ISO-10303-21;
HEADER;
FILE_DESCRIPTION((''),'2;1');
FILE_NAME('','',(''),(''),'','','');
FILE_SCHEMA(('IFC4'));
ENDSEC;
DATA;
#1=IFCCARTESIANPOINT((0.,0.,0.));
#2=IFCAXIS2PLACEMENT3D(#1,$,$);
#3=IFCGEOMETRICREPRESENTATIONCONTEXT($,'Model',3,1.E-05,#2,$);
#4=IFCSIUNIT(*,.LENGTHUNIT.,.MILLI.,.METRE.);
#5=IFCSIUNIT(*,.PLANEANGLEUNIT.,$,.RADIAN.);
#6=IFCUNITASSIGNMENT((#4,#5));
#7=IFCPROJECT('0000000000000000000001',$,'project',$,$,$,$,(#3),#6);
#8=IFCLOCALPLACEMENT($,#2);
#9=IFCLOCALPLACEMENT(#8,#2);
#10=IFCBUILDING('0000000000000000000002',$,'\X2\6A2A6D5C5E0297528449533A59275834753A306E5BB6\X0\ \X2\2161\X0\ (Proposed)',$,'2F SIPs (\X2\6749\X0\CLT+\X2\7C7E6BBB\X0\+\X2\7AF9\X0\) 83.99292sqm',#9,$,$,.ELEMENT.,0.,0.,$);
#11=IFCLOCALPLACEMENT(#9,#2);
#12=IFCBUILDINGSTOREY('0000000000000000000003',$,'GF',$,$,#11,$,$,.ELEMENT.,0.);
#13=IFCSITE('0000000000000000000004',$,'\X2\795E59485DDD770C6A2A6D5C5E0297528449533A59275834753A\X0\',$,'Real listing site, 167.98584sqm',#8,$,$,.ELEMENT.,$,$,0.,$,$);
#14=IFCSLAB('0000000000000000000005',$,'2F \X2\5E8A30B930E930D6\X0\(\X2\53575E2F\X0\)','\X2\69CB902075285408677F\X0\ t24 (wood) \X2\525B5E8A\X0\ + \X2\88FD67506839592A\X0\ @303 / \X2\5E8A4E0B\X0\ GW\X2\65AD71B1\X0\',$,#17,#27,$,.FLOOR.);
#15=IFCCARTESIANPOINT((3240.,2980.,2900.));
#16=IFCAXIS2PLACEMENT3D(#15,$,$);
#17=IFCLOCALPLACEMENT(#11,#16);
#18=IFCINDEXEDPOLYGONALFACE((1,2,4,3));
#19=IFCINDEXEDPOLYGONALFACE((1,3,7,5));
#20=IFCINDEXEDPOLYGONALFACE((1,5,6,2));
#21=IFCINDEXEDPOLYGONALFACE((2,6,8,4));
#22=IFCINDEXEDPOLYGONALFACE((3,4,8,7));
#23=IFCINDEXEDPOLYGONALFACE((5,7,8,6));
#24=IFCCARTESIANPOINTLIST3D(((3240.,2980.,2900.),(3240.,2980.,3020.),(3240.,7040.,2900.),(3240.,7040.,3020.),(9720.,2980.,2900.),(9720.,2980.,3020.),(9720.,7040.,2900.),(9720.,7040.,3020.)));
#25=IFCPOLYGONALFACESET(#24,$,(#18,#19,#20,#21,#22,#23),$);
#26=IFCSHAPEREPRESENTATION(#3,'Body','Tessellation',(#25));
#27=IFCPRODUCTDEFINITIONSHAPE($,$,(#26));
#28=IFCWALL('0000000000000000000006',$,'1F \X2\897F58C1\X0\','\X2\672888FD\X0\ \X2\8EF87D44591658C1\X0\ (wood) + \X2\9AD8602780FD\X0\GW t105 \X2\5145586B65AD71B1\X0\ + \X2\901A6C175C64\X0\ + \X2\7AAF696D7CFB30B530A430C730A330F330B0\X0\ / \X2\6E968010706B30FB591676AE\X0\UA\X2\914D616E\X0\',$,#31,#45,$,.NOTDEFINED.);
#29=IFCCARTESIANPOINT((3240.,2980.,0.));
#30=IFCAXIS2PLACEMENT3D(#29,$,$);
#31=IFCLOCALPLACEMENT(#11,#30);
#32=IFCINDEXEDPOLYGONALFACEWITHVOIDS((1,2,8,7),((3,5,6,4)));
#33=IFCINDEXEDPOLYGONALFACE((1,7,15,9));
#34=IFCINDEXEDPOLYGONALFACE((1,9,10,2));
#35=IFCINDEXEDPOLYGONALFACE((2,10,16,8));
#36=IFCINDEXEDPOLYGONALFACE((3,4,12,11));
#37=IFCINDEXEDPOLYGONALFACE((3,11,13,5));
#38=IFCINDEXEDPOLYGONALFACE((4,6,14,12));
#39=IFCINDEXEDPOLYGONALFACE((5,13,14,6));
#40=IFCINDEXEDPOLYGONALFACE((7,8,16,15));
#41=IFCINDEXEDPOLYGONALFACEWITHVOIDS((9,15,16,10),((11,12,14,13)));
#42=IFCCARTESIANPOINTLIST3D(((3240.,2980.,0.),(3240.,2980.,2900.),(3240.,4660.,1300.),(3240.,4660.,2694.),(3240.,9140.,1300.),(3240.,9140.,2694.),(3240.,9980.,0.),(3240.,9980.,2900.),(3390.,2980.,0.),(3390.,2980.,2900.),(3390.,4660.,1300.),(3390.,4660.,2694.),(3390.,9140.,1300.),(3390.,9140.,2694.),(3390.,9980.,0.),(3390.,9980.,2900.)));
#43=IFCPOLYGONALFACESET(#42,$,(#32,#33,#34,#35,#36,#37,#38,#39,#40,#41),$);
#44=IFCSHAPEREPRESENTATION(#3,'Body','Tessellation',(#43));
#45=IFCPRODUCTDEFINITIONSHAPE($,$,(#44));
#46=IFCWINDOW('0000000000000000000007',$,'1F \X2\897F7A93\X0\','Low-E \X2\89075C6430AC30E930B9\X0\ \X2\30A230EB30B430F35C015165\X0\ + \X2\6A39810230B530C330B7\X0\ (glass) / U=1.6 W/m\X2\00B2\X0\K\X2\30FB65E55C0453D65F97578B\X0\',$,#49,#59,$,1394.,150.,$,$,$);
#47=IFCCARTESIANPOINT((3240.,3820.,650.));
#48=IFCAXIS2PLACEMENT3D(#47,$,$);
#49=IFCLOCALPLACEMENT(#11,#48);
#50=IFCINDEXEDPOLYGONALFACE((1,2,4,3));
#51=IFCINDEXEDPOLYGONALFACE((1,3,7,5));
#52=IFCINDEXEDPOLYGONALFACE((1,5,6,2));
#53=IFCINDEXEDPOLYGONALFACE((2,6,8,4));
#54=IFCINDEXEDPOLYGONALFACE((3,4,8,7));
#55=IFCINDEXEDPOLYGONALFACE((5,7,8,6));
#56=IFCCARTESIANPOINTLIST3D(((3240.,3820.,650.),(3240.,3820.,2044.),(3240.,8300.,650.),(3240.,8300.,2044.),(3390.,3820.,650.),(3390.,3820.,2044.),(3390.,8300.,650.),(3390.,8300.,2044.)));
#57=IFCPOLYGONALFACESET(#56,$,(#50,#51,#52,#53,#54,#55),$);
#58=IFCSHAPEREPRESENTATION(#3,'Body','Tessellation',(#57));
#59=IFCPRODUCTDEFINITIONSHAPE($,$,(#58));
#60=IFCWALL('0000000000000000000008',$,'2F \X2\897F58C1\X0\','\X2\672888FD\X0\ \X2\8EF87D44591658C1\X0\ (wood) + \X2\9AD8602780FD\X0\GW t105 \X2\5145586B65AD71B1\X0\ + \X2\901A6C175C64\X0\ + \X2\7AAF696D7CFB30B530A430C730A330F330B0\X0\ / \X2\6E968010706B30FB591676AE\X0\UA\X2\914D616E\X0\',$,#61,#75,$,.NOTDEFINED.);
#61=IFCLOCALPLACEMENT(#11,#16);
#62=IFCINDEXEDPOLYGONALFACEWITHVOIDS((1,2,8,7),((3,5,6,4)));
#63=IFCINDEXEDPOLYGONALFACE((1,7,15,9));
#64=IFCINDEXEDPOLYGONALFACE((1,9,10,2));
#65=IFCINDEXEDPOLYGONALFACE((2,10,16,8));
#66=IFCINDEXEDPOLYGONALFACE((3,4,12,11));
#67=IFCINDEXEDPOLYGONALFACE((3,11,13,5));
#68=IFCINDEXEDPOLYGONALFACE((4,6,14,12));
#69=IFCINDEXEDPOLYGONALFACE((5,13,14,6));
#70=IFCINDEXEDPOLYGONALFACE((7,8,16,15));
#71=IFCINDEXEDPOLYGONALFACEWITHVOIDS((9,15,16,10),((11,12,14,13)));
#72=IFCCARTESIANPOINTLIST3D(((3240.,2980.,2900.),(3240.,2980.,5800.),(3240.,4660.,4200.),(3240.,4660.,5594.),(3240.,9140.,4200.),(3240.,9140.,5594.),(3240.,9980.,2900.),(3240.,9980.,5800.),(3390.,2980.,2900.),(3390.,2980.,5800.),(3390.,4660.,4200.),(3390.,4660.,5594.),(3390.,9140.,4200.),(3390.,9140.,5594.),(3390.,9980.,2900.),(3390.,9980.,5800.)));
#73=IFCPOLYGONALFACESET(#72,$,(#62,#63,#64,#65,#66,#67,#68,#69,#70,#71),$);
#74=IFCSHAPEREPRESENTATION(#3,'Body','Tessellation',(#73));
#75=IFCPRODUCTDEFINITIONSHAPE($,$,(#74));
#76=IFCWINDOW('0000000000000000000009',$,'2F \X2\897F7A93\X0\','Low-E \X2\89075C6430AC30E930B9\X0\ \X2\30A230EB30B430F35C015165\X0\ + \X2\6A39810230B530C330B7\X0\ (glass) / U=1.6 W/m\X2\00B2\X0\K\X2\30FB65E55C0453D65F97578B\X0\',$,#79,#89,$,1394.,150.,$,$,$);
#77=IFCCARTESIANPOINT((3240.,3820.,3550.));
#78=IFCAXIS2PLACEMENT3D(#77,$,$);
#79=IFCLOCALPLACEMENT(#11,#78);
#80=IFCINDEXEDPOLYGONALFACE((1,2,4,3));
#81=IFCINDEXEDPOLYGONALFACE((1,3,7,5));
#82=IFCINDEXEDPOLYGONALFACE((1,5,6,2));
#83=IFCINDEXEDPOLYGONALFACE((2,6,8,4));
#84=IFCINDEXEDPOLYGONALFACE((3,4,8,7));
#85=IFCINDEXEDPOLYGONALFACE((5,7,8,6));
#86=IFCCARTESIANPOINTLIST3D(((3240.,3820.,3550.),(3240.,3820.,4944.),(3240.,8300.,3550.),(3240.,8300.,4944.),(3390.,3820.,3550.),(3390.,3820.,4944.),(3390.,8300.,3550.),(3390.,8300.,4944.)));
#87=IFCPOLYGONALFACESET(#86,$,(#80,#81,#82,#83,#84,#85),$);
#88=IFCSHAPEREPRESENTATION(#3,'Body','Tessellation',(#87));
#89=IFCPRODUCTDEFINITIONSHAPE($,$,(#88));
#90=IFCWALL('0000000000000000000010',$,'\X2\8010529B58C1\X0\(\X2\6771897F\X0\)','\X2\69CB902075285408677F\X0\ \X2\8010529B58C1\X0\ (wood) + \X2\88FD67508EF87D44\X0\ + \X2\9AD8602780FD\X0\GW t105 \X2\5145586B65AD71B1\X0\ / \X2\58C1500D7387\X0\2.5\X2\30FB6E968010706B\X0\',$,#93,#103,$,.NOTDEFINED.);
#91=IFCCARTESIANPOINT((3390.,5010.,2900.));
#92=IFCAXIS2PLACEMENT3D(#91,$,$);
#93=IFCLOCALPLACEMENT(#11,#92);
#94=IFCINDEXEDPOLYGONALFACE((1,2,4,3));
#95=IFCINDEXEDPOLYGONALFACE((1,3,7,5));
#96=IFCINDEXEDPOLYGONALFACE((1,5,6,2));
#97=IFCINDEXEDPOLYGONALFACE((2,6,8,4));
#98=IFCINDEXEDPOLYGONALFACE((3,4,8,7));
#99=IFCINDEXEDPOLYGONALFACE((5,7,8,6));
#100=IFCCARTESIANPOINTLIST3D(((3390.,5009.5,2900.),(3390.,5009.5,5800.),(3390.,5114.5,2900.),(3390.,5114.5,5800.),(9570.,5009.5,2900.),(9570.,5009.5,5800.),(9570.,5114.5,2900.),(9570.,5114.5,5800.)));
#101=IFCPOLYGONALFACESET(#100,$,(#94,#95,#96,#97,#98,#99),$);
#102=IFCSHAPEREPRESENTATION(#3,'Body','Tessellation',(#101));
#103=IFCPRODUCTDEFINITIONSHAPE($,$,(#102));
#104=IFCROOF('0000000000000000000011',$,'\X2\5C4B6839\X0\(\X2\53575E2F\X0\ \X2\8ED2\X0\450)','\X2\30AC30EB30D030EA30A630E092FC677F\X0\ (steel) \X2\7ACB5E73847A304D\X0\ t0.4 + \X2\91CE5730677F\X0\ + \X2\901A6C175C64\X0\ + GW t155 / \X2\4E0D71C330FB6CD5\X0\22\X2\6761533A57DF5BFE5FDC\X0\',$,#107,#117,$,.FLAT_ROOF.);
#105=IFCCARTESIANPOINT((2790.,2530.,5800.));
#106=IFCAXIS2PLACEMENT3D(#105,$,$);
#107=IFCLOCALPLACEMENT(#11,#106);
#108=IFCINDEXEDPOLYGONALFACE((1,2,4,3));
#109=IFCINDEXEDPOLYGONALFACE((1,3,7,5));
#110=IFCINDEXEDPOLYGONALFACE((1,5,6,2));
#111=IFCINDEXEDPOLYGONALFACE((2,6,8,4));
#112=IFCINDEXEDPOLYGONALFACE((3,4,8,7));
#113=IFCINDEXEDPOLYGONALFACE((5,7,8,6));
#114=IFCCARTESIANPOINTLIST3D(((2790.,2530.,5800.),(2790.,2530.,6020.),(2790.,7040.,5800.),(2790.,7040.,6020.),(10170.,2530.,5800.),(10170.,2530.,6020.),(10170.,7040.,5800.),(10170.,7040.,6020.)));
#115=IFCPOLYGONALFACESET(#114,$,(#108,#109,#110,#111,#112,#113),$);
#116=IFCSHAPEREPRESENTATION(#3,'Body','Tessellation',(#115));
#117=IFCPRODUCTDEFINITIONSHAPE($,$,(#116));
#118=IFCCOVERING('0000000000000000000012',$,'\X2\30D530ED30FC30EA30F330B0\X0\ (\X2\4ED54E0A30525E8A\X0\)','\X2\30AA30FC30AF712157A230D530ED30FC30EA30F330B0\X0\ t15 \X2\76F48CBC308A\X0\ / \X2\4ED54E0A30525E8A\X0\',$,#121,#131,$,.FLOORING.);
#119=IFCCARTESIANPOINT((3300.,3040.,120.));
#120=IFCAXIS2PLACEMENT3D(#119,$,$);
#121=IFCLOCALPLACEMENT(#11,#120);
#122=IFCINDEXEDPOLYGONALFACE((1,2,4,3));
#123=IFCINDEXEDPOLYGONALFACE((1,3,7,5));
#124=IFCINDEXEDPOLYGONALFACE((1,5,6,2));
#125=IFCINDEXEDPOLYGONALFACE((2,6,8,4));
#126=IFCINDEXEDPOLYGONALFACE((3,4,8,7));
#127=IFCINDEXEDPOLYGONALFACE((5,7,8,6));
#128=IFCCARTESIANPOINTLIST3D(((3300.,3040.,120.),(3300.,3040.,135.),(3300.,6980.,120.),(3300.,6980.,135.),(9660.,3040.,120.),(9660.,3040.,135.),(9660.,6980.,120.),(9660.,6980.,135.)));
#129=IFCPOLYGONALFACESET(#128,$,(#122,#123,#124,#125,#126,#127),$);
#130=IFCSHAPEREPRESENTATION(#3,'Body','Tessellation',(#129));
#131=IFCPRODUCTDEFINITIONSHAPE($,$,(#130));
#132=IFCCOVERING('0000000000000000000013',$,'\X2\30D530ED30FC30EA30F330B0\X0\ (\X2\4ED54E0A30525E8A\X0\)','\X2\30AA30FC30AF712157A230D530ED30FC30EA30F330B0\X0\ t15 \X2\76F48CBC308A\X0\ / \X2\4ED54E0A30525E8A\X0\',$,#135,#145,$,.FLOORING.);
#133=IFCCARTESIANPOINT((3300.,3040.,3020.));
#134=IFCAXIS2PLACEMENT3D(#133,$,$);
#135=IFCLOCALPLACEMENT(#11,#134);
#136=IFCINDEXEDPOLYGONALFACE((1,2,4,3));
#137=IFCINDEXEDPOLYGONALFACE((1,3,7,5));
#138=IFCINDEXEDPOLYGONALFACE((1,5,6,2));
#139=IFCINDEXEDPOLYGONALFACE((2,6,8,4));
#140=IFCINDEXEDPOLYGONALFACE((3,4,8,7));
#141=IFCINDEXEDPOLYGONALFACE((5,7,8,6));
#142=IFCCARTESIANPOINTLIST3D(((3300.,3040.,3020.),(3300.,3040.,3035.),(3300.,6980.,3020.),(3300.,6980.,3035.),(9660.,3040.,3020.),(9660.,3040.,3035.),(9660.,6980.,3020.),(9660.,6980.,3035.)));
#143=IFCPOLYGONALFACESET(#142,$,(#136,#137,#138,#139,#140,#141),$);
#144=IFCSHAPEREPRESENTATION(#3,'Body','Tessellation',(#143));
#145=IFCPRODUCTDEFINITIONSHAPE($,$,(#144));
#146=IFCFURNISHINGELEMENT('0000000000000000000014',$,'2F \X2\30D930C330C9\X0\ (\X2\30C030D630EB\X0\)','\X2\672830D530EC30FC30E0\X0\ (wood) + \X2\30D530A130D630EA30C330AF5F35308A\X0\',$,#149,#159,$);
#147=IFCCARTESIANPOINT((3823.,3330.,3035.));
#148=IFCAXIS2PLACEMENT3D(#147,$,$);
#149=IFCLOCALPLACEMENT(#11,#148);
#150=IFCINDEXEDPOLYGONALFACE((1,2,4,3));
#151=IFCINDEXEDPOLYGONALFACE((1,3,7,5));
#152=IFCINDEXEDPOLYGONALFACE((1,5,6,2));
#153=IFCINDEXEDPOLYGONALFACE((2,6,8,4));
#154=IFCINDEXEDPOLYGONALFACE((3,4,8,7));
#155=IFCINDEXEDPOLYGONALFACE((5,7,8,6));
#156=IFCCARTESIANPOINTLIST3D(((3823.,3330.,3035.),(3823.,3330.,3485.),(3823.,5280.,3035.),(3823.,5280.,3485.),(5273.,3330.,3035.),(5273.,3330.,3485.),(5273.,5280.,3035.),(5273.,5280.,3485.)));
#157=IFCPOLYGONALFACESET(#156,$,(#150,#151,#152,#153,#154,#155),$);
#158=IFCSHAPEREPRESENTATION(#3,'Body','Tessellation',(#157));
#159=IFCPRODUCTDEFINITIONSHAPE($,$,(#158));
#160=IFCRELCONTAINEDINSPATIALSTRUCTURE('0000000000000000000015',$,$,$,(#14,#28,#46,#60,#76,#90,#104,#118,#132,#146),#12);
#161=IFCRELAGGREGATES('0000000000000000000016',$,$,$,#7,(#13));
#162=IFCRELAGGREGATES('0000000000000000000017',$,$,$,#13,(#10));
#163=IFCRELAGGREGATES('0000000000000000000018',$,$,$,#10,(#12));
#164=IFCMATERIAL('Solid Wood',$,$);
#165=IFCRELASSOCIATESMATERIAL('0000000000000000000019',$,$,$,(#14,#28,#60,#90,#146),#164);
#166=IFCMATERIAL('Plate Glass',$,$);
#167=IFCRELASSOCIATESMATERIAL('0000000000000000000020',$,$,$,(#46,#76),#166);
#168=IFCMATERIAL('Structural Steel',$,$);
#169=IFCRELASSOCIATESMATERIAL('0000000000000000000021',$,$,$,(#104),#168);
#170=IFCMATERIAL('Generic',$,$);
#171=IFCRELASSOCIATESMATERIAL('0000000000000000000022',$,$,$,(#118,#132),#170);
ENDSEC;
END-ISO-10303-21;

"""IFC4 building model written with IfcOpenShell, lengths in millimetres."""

from ifc_helpers import new_model, si_unit, frame, frame_2d, origin, place, context, project, spatial, rectangle, extrude, material, element, fill, save


model = new_model("IFC4")

# Units and contexts
model_context = context("Model", 3, precision=1e-05, world=origin())
ifc_project = project(units=[si_unit("LENGTHUNIT", "METRE", prefix="MILLI"), si_unit("PLANEANGLEUNIT", "RADIAN")], contexts=[model_context])

# Site, building, storey
site_placement = place(None, origin())
site = spatial("IfcSite", under=ifc_project, at=site_placement, Name="神奈川県横浜市青葉区大場町", ObjectType="Real listing site, 167.98584sqm", CompositionType="ELEMENT", RefElevation=0.0)
building_placement = place(site_placement, origin())
building = spatial("IfcBuilding", under=site, at=building_placement, Name="横浜市青葉区大場町の家 Ⅱ (Proposed)", ObjectType="2F SIPs (杉CLT+籾殻+竹) 83.99292sqm", CompositionType="ELEMENT", ElevationOfRefHeight=0.0, ElevationOfTerrain=0.0)
storey_placement = place(building_placement, origin())
storey = spatial("IfcBuildingStorey", under=building, at=storey_placement, Name="GF", CompositionType="ELEMENT", Elevation=0.0)

# Slab
ifc_material_1 = material(Name="Solid Wood")
slab_1_placement = place(storey_placement, frame((3240.0, 2980.0, 2900.0)))
element("IfcSlab", 1, at=slab_1_placement, inside=storey, material=ifc_material_1, Name="2F 床スラブ(南帯)", Description="構造用合板 t24 (wood) 剛床 + 製材根太 @303 / 床下 GW断熱", PredefinedType="FLOOR", context=model_context, shape_type="SweptSolid", body=[
    extrude(rectangle(XDim=6480.0, YDim=4060.0, at=frame_2d((3240.0, 2030.0))), frame((3240.0, 2980.0, 2900.0)), (0.0, 0.0, 1.0), 120.0),
])

# Shared definitions
ifc_material_2 = material(Name="Plate Glass")

# Wall, opening, window
wall_1_placement = place(storey_placement, frame((3240.0, 2980.0, 0.0)))
wall_1 = element("IfcWall", 2, at=wall_1_placement, inside=storey, material=ifc_material_1, Name="1F 西壁", Description="木製 軸組外壁 (wood) + 高性能GW t105 充填断熱 + 通気層 + 窯業系サイディング / 準耐火・外皮UA配慮", PredefinedType="NOTDEFINED", context=model_context, shape_type="SweptSolid", body=[
    extrude(rectangle(XDim=150.0, YDim=7000.0, at=frame_2d((75.0, 3500.0))), frame((3240.0, 2980.0, 0.0)), (0.0, 0.0, 1.0), 2900.0),
])
opening_1_placement = place(storey_placement, frame((3240.0, 3820.0, 650.0)))
opening_1 = element("IfcOpeningElement", 3, at=opening_1_placement, cuts=wall_1, PredefinedType="NOTDEFINED", context=model_context, shape_type="SweptSolid", body=[
    extrude(rectangle(XDim=150.0, YDim=4480.0, at=frame_2d((75.0, 2240.0))), frame((3240.0, 3820.0, 650.0)), (0.0, 0.0, 1.0), 1394.0),
])
window_1_placement = place(storey_placement, frame((3240.0, 3820.0, 650.0)))
window_1 = element("IfcWindow", 4, at=window_1_placement, inside=storey, material=ifc_material_2, Name="1F 西窓", Description="Low-E 複層ガラス アルゴン封入 + 樹脂サッシ (glass) / U=1.6 W/m²K・日射取得型", OverallHeight=1394.0, OverallWidth=150.0, context=model_context, shape_type="SweptSolid", body=[
    extrude(rectangle(XDim=150.0, YDim=4480.0, at=frame_2d((75.0, 2240.0))), frame((3240.0, 3820.0, 650.0)), (0.0, 0.0, 1.0), 1394.0),
])
fill(opening_1, window_1)

# Wall, opening, window
wall_2_placement = place(storey_placement, frame((3240.0, 2980.0, 2900.0)))
wall_2 = element("IfcWall", 5, at=wall_2_placement, inside=storey, material=ifc_material_1, Name="2F 西壁", Description="木製 軸組外壁 (wood) + 高性能GW t105 充填断熱 + 通気層 + 窯業系サイディング / 準耐火・外皮UA配慮", PredefinedType="NOTDEFINED", context=model_context, shape_type="SweptSolid", body=[
    extrude(rectangle(XDim=150.0, YDim=7000.0, at=frame_2d((75.0, 3500.0))), frame((3240.0, 2980.0, 2900.0)), (0.0, 0.0, 1.0), 2900.0),
])
opening_2_placement = place(storey_placement, frame((3240.0, 3820.0, 3550.0)))
opening_2 = element("IfcOpeningElement", 6, at=opening_2_placement, cuts=wall_2, PredefinedType="NOTDEFINED", context=model_context, shape_type="SweptSolid", body=[
    extrude(rectangle(XDim=150.0, YDim=4480.0, at=frame_2d((75.0, 2240.0))), frame((3240.0, 3820.0, 3550.0)), (0.0, 0.0, 1.0), 1394.0),
])
window_2_placement = place(storey_placement, frame((3240.0, 3820.0, 3550.0)))
window_2 = element("IfcWindow", 7, at=window_2_placement, inside=storey, material=ifc_material_2, Name="2F 西窓", Description="Low-E 複層ガラス アルゴン封入 + 樹脂サッシ (glass) / U=1.6 W/m²K・日射取得型", OverallHeight=1394.0, OverallWidth=150.0, context=model_context, shape_type="SweptSolid", body=[
    extrude(rectangle(XDim=150.0, YDim=4480.0, at=frame_2d((75.0, 2240.0))), frame((3240.0, 3820.0, 3550.0)), (0.0, 0.0, 1.0), 1394.0),
])
fill(opening_2, window_2)

# Wall
wall_3_placement = place(storey_placement, frame((3390.0, 5010.0, 2900.0)))
element("IfcWall", 8, at=wall_3_placement, inside=storey, material=ifc_material_1, Name="耐力壁(東西)", Description="構造用合板 耐力壁 (wood) + 製材軸組 + 高性能GW t105 充填断熱 / 壁倍率2.5・準耐火", PredefinedType="NOTDEFINED", context=model_context, shape_type="SweptSolid", body=[
    extrude(rectangle(XDim=6180.0, YDim=105.0, at=frame_2d((3090.0, 52.0))), frame((3390.0, 5010.0, 2900.0)), (0.0, 0.0, 1.0), 2900.0),
])

# Roof
ifc_material_3 = material(Name="Structural Steel")
for number, where, name in (
    (9, (2790.0, 2530.0, 5800.0), "屋根(南帯 軒450)"),
):
    element("IfcRoof", number, at=place(storey_placement, frame(where)), inside=storey, material=ifc_material_3, Name=name, Description="ガルバリウム鋼板 (steel) 立平葺き t0.4 + 野地板 + 通気層 + GW t155 / 不燃・法22条区域対応", PredefinedType="FLAT_ROOF", context=model_context, shape_type="SweptSolid", body=[
        extrude(rectangle(XDim=7380.0, YDim=4510.0, at=frame_2d((3690.0, 2255.0))), frame((2790.0, 2530.0, 5800.0)), (0.0, 0.0, 1.0), 220.0),
    ])

# Coverings
ifc_material_4 = material(Name="Generic")
covering_1_placement = place(storey_placement, frame((3300.0, 3040.0, 120.0)))
element("IfcCovering", 10, at=covering_1_placement, inside=storey, material=ifc_material_4, Name="フローリング (仕上げ床)", Description="オーク無垢フローリング t15 直貼り / 仕上げ床", PredefinedType="FLOORING", context=model_context, shape_type="SweptSolid", body=[
    extrude(rectangle(XDim=6360.0, YDim=3940.0, at=frame_2d((3180.0, 1970.0))), frame((3300.0, 3040.0, 120.0)), (0.0, 0.0, 1.0), 15.0),
])
covering_2_placement = place(storey_placement, frame((3300.0, 3040.0, 3020.0)))
element("IfcCovering", 11, at=covering_2_placement, inside=storey, material=ifc_material_4, Name="フローリング (仕上げ床)", Description="オーク無垢フローリング t15 直貼り / 仕上げ床", PredefinedType="FLOORING", context=model_context, shape_type="SweptSolid", body=[
    extrude(rectangle(XDim=6360.0, YDim=3940.0, at=frame_2d((3180.0, 1970.0))), frame((3300.0, 3040.0, 3020.0)), (0.0, 0.0, 1.0), 15.0),
])

# Furnishing element
furnishing_placement = place(storey_placement, frame((3823.0, 3330.0, 3035.0)))
element("IfcFurnishingElement", 12, at=furnishing_placement, inside=storey, material=ifc_material_1, Name="2F ベッド (ダブル)", Description="木フレーム (wood) + ファブリック張り", context=model_context, shape_type="SweptSolid", body=[
    extrude(rectangle(XDim=1450.0, YDim=1950.0, at=frame_2d((725.0, 975.0))), frame((3823.0, 3330.0, 3035.0)), (0.0, 0.0, 1.0), 450.0),
])

save(model, "model.ifc")
